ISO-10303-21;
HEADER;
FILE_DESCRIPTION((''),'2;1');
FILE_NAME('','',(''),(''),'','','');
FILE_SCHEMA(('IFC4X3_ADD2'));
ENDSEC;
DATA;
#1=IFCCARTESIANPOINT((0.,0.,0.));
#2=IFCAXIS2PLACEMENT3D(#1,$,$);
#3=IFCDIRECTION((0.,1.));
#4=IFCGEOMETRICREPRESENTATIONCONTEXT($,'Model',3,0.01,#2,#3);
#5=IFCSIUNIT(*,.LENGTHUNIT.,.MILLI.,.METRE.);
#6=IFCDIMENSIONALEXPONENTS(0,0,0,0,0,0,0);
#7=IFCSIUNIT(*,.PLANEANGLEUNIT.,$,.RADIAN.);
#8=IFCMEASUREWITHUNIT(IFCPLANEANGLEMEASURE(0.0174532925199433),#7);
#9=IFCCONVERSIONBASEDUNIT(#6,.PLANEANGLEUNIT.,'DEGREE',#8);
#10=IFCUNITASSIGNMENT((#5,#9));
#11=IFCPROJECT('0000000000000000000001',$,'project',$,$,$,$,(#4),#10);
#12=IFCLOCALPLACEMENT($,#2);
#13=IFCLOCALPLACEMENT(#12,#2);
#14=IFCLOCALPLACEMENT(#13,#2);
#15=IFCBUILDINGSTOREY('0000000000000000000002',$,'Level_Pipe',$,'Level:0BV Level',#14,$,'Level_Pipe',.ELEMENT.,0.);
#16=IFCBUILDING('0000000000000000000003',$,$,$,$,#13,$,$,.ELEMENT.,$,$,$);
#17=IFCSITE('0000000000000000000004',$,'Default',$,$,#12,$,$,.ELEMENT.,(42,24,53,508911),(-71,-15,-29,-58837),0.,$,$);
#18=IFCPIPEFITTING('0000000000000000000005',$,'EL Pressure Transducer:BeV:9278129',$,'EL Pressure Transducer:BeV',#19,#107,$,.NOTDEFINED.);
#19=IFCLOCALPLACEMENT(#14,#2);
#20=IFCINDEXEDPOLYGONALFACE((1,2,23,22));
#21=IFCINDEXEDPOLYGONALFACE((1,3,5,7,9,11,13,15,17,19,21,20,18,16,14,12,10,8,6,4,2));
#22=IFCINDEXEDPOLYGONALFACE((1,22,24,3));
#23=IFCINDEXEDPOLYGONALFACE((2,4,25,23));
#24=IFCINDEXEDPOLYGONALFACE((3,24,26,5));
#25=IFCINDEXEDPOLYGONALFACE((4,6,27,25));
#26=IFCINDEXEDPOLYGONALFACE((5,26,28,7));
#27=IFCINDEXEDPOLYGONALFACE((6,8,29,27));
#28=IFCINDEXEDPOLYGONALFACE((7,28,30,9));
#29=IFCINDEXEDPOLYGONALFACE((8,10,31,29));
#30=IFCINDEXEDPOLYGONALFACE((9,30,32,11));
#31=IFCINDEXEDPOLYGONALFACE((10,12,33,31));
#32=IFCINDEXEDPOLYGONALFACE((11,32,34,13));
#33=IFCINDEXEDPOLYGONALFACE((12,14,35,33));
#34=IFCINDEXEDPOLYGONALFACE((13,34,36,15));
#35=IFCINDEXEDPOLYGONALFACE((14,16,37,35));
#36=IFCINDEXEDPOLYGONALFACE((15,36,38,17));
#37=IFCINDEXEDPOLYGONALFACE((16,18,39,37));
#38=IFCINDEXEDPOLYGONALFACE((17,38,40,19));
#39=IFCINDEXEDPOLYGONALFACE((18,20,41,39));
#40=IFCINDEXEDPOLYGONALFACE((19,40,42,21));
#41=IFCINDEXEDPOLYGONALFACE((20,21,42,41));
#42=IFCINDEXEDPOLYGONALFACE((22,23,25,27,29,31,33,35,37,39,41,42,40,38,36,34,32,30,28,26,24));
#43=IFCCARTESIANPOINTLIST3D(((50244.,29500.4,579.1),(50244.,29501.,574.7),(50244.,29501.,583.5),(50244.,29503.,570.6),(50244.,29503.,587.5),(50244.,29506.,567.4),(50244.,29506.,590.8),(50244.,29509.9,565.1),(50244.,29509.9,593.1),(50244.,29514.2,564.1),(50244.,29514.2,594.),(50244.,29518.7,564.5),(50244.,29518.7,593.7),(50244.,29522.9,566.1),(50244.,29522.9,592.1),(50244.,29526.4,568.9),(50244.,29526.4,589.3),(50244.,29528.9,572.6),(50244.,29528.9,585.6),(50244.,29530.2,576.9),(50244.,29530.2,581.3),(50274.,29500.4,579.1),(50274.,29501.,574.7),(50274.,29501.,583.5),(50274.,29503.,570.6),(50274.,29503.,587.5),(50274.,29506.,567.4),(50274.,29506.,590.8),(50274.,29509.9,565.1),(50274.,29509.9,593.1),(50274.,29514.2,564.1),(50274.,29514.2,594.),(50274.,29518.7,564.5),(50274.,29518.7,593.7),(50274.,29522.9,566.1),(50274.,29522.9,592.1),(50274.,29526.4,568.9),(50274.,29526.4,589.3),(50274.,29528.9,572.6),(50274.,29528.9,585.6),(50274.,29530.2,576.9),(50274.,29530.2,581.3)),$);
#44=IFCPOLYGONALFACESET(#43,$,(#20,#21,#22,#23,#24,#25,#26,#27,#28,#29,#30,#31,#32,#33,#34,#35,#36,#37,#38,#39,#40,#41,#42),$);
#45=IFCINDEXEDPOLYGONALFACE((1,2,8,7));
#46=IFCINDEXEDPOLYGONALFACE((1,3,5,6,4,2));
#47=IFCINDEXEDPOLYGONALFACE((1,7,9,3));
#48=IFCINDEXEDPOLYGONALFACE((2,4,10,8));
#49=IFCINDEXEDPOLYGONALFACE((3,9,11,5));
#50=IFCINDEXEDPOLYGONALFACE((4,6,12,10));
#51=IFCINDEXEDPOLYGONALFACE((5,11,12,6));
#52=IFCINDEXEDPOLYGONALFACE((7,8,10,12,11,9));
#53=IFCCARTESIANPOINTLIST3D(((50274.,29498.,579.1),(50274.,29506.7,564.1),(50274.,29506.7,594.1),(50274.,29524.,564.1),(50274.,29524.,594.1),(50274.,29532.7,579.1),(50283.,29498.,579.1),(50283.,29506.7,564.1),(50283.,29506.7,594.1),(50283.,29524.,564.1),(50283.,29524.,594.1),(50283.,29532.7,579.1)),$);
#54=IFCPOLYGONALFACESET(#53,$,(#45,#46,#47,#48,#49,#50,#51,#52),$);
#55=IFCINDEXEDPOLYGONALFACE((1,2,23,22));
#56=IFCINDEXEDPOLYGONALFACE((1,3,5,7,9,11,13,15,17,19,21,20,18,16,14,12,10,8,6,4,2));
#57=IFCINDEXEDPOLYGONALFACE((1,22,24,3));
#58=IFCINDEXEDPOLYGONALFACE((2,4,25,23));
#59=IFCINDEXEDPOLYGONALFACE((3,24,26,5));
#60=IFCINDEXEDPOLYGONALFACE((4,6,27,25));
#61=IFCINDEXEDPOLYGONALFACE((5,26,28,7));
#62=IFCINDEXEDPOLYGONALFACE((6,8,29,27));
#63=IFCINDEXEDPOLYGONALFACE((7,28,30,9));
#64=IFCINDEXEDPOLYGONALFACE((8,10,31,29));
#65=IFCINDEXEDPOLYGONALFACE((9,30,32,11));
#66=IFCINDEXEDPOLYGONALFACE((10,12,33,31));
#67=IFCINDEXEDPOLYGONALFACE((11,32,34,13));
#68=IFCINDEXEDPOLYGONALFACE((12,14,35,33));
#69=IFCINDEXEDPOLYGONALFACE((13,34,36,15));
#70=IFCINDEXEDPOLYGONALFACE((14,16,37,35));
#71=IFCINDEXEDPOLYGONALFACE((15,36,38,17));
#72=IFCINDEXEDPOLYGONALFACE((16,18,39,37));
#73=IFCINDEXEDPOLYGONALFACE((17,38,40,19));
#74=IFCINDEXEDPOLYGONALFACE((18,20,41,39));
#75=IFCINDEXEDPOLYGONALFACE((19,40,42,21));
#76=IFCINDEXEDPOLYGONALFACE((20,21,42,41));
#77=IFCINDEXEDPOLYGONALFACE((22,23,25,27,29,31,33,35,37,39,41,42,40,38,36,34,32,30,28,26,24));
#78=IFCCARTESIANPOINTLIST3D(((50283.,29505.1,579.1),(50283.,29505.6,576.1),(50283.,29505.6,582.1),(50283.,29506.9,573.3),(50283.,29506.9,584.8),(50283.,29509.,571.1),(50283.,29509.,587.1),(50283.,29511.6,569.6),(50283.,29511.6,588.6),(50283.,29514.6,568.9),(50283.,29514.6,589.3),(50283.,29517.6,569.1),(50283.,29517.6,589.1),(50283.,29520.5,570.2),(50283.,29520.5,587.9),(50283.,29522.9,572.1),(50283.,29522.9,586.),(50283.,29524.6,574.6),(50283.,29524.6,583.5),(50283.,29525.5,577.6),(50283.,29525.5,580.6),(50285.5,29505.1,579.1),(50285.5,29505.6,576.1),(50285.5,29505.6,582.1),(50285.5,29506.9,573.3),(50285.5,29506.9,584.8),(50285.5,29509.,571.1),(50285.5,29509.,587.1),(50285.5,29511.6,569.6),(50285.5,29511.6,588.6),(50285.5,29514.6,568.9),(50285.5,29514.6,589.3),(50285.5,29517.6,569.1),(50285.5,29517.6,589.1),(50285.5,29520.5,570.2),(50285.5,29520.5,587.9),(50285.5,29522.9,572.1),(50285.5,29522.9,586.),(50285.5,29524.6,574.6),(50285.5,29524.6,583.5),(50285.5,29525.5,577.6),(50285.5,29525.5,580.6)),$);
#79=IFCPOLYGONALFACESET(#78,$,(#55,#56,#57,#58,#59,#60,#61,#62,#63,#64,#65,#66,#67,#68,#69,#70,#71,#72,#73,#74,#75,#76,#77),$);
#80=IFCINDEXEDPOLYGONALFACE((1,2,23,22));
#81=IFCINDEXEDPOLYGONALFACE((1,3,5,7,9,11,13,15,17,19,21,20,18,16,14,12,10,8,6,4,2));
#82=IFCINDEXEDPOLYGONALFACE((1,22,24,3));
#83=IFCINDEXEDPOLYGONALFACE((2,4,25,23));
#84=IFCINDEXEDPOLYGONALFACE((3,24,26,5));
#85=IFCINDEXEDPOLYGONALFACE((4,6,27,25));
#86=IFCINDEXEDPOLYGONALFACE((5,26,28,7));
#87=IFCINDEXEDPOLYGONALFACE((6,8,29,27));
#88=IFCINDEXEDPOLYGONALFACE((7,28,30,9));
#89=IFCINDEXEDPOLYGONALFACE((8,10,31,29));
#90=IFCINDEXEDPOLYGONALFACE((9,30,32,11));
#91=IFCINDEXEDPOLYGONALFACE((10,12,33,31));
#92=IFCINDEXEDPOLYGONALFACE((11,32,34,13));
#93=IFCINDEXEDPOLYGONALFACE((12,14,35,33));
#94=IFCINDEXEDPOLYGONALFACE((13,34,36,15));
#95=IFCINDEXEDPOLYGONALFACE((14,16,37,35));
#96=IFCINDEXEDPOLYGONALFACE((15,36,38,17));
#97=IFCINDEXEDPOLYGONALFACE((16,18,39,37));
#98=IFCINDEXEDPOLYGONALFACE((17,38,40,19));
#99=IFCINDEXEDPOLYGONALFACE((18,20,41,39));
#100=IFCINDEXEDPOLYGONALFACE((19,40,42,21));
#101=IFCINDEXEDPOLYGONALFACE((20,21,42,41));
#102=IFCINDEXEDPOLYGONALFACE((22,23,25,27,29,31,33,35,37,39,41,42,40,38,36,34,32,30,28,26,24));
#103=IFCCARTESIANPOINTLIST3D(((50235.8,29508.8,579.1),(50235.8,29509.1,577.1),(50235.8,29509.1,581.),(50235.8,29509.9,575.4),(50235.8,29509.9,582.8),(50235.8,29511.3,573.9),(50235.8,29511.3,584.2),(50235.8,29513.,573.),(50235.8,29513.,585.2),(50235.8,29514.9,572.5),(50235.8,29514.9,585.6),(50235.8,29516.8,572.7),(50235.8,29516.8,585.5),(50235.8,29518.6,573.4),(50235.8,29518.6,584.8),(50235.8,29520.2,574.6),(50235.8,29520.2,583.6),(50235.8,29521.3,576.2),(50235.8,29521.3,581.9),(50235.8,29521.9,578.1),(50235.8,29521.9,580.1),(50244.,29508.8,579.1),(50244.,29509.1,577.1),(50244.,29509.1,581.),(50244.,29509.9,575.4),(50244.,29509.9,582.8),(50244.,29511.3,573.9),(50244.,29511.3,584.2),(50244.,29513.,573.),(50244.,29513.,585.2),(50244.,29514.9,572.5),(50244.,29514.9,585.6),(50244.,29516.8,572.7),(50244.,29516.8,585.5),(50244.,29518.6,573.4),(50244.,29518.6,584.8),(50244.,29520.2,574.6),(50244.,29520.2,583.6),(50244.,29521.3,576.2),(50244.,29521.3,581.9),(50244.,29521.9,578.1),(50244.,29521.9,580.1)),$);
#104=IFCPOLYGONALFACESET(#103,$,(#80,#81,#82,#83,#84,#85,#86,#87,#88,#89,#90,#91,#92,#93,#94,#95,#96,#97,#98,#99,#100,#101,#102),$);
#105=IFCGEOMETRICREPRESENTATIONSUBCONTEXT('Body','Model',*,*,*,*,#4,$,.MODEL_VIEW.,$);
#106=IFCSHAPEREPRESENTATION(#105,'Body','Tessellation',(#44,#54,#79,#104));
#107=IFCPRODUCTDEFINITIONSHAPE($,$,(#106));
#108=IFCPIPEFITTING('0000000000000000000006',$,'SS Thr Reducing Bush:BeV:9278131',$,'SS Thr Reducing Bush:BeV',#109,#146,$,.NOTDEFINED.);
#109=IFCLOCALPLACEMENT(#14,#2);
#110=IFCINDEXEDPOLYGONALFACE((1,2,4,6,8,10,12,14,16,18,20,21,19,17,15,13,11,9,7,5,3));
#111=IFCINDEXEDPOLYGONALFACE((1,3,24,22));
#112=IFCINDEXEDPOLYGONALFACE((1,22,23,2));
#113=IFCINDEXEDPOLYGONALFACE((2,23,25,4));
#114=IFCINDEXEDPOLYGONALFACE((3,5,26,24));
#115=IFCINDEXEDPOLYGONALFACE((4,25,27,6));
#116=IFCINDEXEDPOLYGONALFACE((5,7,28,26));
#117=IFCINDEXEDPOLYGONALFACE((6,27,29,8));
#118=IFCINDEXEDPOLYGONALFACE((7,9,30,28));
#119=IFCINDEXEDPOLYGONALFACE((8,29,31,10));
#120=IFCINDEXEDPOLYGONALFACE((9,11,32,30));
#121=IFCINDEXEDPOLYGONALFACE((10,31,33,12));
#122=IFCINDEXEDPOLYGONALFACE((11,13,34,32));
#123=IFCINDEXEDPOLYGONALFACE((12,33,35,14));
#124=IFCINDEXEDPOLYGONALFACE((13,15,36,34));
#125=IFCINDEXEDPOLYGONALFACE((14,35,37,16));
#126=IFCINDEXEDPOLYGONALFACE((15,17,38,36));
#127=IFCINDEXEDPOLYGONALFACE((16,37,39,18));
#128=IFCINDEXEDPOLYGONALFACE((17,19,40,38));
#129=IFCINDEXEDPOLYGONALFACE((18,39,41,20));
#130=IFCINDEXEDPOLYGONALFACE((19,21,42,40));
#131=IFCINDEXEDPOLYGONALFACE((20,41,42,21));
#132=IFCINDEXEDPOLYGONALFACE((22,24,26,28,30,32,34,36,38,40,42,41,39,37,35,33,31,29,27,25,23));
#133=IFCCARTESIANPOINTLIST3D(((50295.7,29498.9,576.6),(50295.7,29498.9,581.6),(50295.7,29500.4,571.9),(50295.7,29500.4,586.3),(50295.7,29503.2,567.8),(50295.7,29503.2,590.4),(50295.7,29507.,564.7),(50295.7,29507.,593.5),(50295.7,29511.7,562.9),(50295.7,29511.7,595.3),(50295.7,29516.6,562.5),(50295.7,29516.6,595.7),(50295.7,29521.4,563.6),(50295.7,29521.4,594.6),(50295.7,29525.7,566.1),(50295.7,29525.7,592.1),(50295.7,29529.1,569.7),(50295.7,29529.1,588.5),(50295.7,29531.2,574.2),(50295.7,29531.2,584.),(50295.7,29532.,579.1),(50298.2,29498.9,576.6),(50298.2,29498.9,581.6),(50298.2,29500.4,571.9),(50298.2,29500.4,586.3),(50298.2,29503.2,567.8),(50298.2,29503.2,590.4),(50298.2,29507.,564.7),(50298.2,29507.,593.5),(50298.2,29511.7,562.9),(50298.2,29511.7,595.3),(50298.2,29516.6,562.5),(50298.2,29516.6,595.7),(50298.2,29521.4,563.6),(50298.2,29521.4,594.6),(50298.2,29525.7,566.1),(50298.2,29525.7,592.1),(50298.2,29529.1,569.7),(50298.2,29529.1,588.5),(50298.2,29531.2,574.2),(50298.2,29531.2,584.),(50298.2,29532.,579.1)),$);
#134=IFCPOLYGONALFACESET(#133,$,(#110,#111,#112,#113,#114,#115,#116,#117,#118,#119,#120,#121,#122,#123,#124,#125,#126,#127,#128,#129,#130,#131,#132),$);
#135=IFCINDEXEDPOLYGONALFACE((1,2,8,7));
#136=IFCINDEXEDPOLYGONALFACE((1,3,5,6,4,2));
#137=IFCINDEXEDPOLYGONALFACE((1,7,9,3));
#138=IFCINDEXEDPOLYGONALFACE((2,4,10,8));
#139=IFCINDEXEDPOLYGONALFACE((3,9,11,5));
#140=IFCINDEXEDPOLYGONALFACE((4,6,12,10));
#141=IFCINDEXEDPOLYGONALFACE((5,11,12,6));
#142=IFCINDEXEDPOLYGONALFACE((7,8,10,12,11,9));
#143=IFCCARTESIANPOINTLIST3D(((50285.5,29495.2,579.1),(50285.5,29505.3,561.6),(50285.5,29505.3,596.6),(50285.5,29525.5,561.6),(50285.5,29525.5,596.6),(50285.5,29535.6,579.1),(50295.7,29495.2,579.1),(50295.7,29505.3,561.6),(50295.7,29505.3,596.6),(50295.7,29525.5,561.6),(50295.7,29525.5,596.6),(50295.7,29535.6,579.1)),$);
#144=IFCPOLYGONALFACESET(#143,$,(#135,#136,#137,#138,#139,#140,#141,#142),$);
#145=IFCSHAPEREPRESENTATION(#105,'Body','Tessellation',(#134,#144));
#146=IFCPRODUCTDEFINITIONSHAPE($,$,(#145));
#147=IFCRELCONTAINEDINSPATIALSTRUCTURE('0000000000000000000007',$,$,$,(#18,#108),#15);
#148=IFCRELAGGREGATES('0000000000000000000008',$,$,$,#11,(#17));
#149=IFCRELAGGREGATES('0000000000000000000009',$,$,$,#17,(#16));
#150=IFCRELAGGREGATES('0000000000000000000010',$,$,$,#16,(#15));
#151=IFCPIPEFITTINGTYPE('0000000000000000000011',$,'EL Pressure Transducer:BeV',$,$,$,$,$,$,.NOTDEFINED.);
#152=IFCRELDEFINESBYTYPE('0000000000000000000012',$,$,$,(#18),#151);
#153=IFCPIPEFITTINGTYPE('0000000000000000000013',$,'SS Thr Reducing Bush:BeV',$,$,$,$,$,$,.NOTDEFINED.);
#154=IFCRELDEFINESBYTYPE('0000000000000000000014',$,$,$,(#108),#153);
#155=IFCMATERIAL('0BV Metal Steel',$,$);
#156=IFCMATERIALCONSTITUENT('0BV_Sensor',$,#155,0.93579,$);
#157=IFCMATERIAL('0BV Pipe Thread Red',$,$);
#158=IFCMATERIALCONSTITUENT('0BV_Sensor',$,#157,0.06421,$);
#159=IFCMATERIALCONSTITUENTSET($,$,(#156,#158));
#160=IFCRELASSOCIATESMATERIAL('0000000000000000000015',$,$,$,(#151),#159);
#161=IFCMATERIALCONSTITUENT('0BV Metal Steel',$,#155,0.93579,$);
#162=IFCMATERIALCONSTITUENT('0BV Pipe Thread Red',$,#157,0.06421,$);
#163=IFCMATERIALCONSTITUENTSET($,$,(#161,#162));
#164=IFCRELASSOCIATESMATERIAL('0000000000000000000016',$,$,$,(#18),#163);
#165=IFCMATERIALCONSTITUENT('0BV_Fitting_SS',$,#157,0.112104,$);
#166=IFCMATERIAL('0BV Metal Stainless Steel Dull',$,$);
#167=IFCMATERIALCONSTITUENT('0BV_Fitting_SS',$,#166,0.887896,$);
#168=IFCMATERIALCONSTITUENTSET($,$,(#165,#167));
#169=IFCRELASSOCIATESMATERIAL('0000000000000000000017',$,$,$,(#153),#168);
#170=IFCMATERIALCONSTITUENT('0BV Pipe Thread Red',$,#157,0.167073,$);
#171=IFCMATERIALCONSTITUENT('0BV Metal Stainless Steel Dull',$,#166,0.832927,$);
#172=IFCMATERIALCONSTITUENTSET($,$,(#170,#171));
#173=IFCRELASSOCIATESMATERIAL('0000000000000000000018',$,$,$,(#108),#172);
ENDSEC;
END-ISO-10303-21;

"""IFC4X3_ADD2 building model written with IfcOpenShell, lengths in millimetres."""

from ifc_helpers import new_model, entity, si_unit, converted_unit, direction, frame, frame_2d, origin, place, context, subcontext, project, spatial, polyline, circle, outline, extrude, source, transform, mapped, material, constituent, constituent_set, type_object, type_shapes, element, save


model = new_model("IFC4X3_ADD2")

# Units and contexts
model_context = context("Model", 3, precision=0.01, world=origin(), true_north=direction((0.0, 1.0)))
body_context = subcontext(model_context, "Body", "Model", "MODEL_VIEW")
ifc_project = project(units=[si_unit("LENGTHUNIT", "METRE", prefix="MILLI"), converted_unit("PLANEANGLEUNIT", "DEGREE", entity("IfcPlaneAngleMeasure", 0.0174532925199433), si_unit("PLANEANGLEUNIT", "RADIAN"), dimensions=[0, 0, 0, 0, 0, 0, 0])], contexts=[model_context])

# Site, building, storey
site_placement = place(None, origin())
site = spatial("IfcSite", under=ifc_project, at=site_placement, Name="Default", CompositionType="ELEMENT", RefLatitude=(42, 24, 53, 508911), RefLongitude=(-71, -15, -29, -58837), RefElevation=0.0)
building_placement = place(site_placement, origin())
building = spatial("IfcBuilding", under=site, at=building_placement, CompositionType="ELEMENT")
storey_placement = place(building_placement, origin())
storey = spatial("IfcBuildingStorey", under=building, at=storey_placement, Name="Level_Pipe", ObjectType="Level:0BV Level", LongName="Level_Pipe", CompositionType="ELEMENT", Elevation=0.0)

# Shared definitions
ifc_material_1 = material(Name="0BV Metal Stainless Steel Dull")

# Shared definitions
ifc_material_2 = material(Name="0BV Metal Steel")
ifc_material_3 = material(Name="0BV Pipe Thread Red")

# Pipe fittings
ifc_constituent_1 = constituent(ifc_material_2, Name="0BV Metal Steel", fraction=0.93579)
ifc_constituent_2 = constituent(ifc_material_3, Name="0BV Pipe Thread Red", fraction=0.06421)
ifc_constituent_set_1 = constituent_set(constituents=[ifc_constituent_1, ifc_constituent_2])
ifc_constituent_3 = constituent(ifc_material_2, Name="0BV_Sensor", fraction=0.93579)
ifc_constituent_4 = constituent(ifc_material_3, Name="0BV_Sensor", fraction=0.06421)
ifc_constituent_set_2 = constituent_set(constituents=[ifc_constituent_3, ifc_constituent_4])
pipe_fitting_type_1 = type_object("IfcPipeFittingType", Name="EL Pressure Transducer:BeV", PredefinedType="NOTDEFINED", material=ifc_constituent_set_2)
shared_shape_1 = source(origin(), body_context, "Body", "SweptSolid", [
    extrude(circle(Radius=15.0, at=frame_2d((0.0, 0.0), x_axis=(1.0, 0.0))), frame((0.0, 0.0, 11.5), z_axis=(0.0, 0.0, 1.0), x_axis=(-1.0, 0.0, 0.0)), (0.0, 0.0, 1.0), 30.0),
    extrude(outline(polyline([(-8.7, -15.0), (8.7, -15.0), (17.3, 0.0), (8.7, 15.0), (-8.7, 15.0), (-17.3, 0.0), (-8.7, -15.0)])), frame((0.0, 0.0, 2.5), z_axis=(0.0, 0.0, 1.0), x_axis=(0.5, 0.866025, 0.0)), (0.0, 0.0, 1.0), 9.0),
    extrude(circle(Radius=10.2, at=frame_2d((0.0, 0.0), x_axis=(1.0, 0.0))), frame((0.0, 0.0, 0.0), z_axis=(0.0, 0.0, 1.0), x_axis=(-1.0, 0.0, 0.0)), (0.0, 0.0, 1.0), 2.5),
    extrude(circle(Radius=6.6, at=frame_2d((0.0, 0.0), x_axis=(1.0, 0.0))), frame((0.0, 0.0, 41.5), z_axis=(0.0, 0.0, 1.0), x_axis=(-1.0, 0.0, 0.0)), (0.0, 0.0, 1.0), 8.2),
])
type_shapes(pipe_fitting_type_1, [shared_shape_1])
pipe_fitting_1_placement = place(storey_placement, frame((50285.5, 29515.4, 579.1), z_axis=(-1.0, 0.0, 0.0), x_axis=(0.0, 1.0, 0.0)))
element("IfcPipeFitting", 1, at=pipe_fitting_1_placement, inside=storey, type_object=pipe_fitting_type_1, material=ifc_constituent_set_1, Name="EL Pressure Transducer:BeV:9278129", ObjectType="EL Pressure Transducer:BeV", PredefinedType="NOTDEFINED", context=body_context, shape_type="MappedRepresentation", body=[
    mapped(shared_shape_1, transform((0.0, 0.0, 0.0), scale=1.0)),
])
ifc_constituent_5 = constituent(ifc_material_3, Name="0BV Pipe Thread Red", fraction=0.167073)
ifc_constituent_6 = constituent(ifc_material_1, Name="0BV Metal Stainless Steel Dull", fraction=0.832927)
ifc_constituent_set_3 = constituent_set(constituents=[ifc_constituent_5, ifc_constituent_6])
ifc_constituent_7 = constituent(ifc_material_3, Name="0BV_Fitting_SS", fraction=0.112104)
ifc_constituent_8 = constituent(ifc_material_1, Name="0BV_Fitting_SS", fraction=0.887896)
ifc_constituent_set_4 = constituent_set(constituents=[ifc_constituent_7, ifc_constituent_8])
pipe_fitting_type_2 = type_object("IfcPipeFittingType", Name="SS Thr Reducing Bush:BeV", PredefinedType="NOTDEFINED", material=ifc_constituent_set_4)
shared_shape_2 = source(origin(), body_context, "Body", "SweptSolid", [
    extrude(circle(Radius=16.6, at=frame_2d((0.0, 0.0), x_axis=(1.0, 0.0))), frame((10.2, 0.0, 0.0), z_axis=(1.0, 0.0, 0.0), x_axis=(0.0, 1.0, 0.0)), (0.0, 0.0, 1.0), 2.5),
    extrude(outline(polyline([(-10.1, -17.5), (10.1, -17.5), (20.2, 0.0), (10.1, 17.5), (-10.1, 17.5), (-20.2, 0.0), (-10.1, -17.5)])), frame((0.0, 0.0, 0.0), z_axis=(1.0, 0.0, 0.0), x_axis=(0.0, -0.5, -0.866025)), (0.0, 0.0, 1.0), 10.2),
])
type_shapes(pipe_fitting_type_2, [shared_shape_2])
pipe_fitting_2_placement = place(storey_placement, frame((50285.5, 29515.4, 579.1)))
element("IfcPipeFitting", 2, at=pipe_fitting_2_placement, inside=storey, type_object=pipe_fitting_type_2, material=ifc_constituent_set_3, Name="SS Thr Reducing Bush:BeV:9278131", ObjectType="SS Thr Reducing Bush:BeV", PredefinedType="NOTDEFINED", context=body_context, shape_type="MappedRepresentation", body=[
    mapped(shared_shape_2, transform((0.0, 0.0, 0.0), scale=1.0)),
])

save(model, "model.ifc")
